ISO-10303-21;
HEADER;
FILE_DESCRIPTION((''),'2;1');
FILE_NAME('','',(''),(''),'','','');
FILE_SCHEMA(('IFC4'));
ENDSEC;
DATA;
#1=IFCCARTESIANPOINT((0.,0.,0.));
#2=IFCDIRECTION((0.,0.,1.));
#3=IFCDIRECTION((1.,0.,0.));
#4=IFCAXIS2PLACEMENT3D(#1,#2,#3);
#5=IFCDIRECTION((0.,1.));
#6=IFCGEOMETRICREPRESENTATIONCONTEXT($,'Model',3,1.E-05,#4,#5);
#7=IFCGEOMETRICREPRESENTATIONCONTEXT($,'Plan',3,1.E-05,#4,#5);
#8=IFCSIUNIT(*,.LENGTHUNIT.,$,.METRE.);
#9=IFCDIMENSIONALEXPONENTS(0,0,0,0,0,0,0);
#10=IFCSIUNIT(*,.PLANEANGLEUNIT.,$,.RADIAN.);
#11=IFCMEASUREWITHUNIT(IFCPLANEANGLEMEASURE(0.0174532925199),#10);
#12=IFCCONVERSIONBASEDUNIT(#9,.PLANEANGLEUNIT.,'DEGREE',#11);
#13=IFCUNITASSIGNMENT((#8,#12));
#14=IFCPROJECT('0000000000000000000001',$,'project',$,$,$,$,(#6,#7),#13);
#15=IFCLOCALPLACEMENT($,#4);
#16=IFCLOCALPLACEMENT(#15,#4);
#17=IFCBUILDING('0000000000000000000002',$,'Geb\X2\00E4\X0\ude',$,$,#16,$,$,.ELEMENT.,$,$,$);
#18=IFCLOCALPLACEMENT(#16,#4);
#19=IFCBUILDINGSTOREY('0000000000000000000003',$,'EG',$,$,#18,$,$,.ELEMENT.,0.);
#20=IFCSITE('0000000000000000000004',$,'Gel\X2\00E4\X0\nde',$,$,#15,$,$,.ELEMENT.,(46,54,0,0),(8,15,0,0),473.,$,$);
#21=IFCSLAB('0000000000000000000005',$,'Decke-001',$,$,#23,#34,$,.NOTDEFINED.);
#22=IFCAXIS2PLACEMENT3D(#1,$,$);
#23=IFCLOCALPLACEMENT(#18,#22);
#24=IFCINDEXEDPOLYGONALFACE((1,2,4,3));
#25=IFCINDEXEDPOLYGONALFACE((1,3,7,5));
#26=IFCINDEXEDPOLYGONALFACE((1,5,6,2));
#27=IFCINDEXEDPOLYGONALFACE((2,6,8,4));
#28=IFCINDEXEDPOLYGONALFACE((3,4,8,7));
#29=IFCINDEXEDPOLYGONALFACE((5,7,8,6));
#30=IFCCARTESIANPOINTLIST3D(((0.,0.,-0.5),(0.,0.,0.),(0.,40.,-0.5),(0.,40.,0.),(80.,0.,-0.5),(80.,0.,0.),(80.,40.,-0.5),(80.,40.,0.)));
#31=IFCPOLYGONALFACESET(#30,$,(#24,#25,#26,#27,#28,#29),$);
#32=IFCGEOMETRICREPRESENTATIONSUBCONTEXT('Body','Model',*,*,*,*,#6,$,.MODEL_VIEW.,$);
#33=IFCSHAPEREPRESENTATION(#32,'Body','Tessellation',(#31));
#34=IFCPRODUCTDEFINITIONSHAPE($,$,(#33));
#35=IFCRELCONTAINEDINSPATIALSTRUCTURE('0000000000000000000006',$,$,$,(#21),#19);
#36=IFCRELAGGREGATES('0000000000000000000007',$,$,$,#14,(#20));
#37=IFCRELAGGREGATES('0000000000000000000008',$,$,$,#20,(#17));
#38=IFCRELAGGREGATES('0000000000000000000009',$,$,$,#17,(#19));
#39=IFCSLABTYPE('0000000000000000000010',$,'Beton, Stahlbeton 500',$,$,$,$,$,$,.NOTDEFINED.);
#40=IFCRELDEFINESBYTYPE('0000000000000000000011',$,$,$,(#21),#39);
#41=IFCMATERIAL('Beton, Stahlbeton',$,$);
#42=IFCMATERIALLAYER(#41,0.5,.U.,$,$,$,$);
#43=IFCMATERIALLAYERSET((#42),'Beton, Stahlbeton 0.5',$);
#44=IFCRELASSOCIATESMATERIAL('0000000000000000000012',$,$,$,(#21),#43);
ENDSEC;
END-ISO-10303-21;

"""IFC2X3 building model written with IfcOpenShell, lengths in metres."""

from ifc_helpers import new_model, entity, si_unit, converted_unit, direction, frame, origin_with_axes, place, context, subcontext, project, spatial, polyline, outline, extrude, material, layer, layer_set, layer_usage, type_object, element, save


model = new_model("IFC2X3")

# Units and contexts
model_context = context("Model", 3, precision=1e-05, world=origin_with_axes(), true_north=direction((0.0, 1.0)))
plan_context = context("Plan", 3, precision=1e-05, world=origin_with_axes(), true_north=direction((0.0, 1.0)))
body_context = subcontext(model_context, "Body", "Model", "MODEL_VIEW")
ifc_project = project(units=[si_unit("LENGTHUNIT", "METRE"), converted_unit("PLANEANGLEUNIT", "DEGREE", entity("IfcPlaneAngleMeasure", 0.0174532925199), si_unit("PLANEANGLEUNIT", "RADIAN"), dimensions=[0, 0, 0, 0, 0, 0, 0])], contexts=[model_context, plan_context])

# Site, building, storey
site_placement = place(None, origin_with_axes())
site = spatial("IfcSite", under=ifc_project, at=site_placement, Name="Gelände", CompositionType="ELEMENT", RefLatitude=(46, 54, 0, 0), RefLongitude=(8, 15, 0, 0), RefElevation=473.0)
building_placement = place(site_placement, origin_with_axes())
building = spatial("IfcBuilding", under=site, at=building_placement, Name="Gebäude", CompositionType="ELEMENT")
storey_placement = place(building_placement, origin_with_axes())
storey = spatial("IfcBuildingStorey", under=building, at=storey_placement, Name="EG", CompositionType="ELEMENT", Elevation=0.0)

# Slab
ifc_material = material(Name="Beton, Stahlbeton")
ifc_layer = layer(ifc_material, 0.5, ventilated="UNKNOWN")
ifc_layer_set = layer_set([ifc_layer], Name="Beton, Stahlbeton 0.5")
ifc_layer_usage = layer_usage(ifc_layer_set, "AXIS3", "NEGATIVE", 0.5)
slab_type = type_object("IfcSlabType", Name="Beton, Stahlbeton 500", PredefinedType="NOTDEFINED")
slab_placement = place(storey_placement, origin_with_axes())
element("IfcSlab", 1, at=slab_placement, inside=storey, type_object=slab_type, material=ifc_layer_usage, Name="Decke-001", PredefinedType="NOTDEFINED", context=body_context, shape_type="SweptSolid", body=[
    extrude(outline(polyline([(0.0, 0.0), (80.0, 0.0), (80.0, 40.0), (0.0, 40.0), (0.0, 0.0)])), frame((0.0, 0.0, -0.5), z_axis=(0.0, 0.0, 1.0), x_axis=(1.0, 0.0, 0.0)), (0.0, 0.0, 1.0), 0.5),
])

save(model, "model.ifc")
